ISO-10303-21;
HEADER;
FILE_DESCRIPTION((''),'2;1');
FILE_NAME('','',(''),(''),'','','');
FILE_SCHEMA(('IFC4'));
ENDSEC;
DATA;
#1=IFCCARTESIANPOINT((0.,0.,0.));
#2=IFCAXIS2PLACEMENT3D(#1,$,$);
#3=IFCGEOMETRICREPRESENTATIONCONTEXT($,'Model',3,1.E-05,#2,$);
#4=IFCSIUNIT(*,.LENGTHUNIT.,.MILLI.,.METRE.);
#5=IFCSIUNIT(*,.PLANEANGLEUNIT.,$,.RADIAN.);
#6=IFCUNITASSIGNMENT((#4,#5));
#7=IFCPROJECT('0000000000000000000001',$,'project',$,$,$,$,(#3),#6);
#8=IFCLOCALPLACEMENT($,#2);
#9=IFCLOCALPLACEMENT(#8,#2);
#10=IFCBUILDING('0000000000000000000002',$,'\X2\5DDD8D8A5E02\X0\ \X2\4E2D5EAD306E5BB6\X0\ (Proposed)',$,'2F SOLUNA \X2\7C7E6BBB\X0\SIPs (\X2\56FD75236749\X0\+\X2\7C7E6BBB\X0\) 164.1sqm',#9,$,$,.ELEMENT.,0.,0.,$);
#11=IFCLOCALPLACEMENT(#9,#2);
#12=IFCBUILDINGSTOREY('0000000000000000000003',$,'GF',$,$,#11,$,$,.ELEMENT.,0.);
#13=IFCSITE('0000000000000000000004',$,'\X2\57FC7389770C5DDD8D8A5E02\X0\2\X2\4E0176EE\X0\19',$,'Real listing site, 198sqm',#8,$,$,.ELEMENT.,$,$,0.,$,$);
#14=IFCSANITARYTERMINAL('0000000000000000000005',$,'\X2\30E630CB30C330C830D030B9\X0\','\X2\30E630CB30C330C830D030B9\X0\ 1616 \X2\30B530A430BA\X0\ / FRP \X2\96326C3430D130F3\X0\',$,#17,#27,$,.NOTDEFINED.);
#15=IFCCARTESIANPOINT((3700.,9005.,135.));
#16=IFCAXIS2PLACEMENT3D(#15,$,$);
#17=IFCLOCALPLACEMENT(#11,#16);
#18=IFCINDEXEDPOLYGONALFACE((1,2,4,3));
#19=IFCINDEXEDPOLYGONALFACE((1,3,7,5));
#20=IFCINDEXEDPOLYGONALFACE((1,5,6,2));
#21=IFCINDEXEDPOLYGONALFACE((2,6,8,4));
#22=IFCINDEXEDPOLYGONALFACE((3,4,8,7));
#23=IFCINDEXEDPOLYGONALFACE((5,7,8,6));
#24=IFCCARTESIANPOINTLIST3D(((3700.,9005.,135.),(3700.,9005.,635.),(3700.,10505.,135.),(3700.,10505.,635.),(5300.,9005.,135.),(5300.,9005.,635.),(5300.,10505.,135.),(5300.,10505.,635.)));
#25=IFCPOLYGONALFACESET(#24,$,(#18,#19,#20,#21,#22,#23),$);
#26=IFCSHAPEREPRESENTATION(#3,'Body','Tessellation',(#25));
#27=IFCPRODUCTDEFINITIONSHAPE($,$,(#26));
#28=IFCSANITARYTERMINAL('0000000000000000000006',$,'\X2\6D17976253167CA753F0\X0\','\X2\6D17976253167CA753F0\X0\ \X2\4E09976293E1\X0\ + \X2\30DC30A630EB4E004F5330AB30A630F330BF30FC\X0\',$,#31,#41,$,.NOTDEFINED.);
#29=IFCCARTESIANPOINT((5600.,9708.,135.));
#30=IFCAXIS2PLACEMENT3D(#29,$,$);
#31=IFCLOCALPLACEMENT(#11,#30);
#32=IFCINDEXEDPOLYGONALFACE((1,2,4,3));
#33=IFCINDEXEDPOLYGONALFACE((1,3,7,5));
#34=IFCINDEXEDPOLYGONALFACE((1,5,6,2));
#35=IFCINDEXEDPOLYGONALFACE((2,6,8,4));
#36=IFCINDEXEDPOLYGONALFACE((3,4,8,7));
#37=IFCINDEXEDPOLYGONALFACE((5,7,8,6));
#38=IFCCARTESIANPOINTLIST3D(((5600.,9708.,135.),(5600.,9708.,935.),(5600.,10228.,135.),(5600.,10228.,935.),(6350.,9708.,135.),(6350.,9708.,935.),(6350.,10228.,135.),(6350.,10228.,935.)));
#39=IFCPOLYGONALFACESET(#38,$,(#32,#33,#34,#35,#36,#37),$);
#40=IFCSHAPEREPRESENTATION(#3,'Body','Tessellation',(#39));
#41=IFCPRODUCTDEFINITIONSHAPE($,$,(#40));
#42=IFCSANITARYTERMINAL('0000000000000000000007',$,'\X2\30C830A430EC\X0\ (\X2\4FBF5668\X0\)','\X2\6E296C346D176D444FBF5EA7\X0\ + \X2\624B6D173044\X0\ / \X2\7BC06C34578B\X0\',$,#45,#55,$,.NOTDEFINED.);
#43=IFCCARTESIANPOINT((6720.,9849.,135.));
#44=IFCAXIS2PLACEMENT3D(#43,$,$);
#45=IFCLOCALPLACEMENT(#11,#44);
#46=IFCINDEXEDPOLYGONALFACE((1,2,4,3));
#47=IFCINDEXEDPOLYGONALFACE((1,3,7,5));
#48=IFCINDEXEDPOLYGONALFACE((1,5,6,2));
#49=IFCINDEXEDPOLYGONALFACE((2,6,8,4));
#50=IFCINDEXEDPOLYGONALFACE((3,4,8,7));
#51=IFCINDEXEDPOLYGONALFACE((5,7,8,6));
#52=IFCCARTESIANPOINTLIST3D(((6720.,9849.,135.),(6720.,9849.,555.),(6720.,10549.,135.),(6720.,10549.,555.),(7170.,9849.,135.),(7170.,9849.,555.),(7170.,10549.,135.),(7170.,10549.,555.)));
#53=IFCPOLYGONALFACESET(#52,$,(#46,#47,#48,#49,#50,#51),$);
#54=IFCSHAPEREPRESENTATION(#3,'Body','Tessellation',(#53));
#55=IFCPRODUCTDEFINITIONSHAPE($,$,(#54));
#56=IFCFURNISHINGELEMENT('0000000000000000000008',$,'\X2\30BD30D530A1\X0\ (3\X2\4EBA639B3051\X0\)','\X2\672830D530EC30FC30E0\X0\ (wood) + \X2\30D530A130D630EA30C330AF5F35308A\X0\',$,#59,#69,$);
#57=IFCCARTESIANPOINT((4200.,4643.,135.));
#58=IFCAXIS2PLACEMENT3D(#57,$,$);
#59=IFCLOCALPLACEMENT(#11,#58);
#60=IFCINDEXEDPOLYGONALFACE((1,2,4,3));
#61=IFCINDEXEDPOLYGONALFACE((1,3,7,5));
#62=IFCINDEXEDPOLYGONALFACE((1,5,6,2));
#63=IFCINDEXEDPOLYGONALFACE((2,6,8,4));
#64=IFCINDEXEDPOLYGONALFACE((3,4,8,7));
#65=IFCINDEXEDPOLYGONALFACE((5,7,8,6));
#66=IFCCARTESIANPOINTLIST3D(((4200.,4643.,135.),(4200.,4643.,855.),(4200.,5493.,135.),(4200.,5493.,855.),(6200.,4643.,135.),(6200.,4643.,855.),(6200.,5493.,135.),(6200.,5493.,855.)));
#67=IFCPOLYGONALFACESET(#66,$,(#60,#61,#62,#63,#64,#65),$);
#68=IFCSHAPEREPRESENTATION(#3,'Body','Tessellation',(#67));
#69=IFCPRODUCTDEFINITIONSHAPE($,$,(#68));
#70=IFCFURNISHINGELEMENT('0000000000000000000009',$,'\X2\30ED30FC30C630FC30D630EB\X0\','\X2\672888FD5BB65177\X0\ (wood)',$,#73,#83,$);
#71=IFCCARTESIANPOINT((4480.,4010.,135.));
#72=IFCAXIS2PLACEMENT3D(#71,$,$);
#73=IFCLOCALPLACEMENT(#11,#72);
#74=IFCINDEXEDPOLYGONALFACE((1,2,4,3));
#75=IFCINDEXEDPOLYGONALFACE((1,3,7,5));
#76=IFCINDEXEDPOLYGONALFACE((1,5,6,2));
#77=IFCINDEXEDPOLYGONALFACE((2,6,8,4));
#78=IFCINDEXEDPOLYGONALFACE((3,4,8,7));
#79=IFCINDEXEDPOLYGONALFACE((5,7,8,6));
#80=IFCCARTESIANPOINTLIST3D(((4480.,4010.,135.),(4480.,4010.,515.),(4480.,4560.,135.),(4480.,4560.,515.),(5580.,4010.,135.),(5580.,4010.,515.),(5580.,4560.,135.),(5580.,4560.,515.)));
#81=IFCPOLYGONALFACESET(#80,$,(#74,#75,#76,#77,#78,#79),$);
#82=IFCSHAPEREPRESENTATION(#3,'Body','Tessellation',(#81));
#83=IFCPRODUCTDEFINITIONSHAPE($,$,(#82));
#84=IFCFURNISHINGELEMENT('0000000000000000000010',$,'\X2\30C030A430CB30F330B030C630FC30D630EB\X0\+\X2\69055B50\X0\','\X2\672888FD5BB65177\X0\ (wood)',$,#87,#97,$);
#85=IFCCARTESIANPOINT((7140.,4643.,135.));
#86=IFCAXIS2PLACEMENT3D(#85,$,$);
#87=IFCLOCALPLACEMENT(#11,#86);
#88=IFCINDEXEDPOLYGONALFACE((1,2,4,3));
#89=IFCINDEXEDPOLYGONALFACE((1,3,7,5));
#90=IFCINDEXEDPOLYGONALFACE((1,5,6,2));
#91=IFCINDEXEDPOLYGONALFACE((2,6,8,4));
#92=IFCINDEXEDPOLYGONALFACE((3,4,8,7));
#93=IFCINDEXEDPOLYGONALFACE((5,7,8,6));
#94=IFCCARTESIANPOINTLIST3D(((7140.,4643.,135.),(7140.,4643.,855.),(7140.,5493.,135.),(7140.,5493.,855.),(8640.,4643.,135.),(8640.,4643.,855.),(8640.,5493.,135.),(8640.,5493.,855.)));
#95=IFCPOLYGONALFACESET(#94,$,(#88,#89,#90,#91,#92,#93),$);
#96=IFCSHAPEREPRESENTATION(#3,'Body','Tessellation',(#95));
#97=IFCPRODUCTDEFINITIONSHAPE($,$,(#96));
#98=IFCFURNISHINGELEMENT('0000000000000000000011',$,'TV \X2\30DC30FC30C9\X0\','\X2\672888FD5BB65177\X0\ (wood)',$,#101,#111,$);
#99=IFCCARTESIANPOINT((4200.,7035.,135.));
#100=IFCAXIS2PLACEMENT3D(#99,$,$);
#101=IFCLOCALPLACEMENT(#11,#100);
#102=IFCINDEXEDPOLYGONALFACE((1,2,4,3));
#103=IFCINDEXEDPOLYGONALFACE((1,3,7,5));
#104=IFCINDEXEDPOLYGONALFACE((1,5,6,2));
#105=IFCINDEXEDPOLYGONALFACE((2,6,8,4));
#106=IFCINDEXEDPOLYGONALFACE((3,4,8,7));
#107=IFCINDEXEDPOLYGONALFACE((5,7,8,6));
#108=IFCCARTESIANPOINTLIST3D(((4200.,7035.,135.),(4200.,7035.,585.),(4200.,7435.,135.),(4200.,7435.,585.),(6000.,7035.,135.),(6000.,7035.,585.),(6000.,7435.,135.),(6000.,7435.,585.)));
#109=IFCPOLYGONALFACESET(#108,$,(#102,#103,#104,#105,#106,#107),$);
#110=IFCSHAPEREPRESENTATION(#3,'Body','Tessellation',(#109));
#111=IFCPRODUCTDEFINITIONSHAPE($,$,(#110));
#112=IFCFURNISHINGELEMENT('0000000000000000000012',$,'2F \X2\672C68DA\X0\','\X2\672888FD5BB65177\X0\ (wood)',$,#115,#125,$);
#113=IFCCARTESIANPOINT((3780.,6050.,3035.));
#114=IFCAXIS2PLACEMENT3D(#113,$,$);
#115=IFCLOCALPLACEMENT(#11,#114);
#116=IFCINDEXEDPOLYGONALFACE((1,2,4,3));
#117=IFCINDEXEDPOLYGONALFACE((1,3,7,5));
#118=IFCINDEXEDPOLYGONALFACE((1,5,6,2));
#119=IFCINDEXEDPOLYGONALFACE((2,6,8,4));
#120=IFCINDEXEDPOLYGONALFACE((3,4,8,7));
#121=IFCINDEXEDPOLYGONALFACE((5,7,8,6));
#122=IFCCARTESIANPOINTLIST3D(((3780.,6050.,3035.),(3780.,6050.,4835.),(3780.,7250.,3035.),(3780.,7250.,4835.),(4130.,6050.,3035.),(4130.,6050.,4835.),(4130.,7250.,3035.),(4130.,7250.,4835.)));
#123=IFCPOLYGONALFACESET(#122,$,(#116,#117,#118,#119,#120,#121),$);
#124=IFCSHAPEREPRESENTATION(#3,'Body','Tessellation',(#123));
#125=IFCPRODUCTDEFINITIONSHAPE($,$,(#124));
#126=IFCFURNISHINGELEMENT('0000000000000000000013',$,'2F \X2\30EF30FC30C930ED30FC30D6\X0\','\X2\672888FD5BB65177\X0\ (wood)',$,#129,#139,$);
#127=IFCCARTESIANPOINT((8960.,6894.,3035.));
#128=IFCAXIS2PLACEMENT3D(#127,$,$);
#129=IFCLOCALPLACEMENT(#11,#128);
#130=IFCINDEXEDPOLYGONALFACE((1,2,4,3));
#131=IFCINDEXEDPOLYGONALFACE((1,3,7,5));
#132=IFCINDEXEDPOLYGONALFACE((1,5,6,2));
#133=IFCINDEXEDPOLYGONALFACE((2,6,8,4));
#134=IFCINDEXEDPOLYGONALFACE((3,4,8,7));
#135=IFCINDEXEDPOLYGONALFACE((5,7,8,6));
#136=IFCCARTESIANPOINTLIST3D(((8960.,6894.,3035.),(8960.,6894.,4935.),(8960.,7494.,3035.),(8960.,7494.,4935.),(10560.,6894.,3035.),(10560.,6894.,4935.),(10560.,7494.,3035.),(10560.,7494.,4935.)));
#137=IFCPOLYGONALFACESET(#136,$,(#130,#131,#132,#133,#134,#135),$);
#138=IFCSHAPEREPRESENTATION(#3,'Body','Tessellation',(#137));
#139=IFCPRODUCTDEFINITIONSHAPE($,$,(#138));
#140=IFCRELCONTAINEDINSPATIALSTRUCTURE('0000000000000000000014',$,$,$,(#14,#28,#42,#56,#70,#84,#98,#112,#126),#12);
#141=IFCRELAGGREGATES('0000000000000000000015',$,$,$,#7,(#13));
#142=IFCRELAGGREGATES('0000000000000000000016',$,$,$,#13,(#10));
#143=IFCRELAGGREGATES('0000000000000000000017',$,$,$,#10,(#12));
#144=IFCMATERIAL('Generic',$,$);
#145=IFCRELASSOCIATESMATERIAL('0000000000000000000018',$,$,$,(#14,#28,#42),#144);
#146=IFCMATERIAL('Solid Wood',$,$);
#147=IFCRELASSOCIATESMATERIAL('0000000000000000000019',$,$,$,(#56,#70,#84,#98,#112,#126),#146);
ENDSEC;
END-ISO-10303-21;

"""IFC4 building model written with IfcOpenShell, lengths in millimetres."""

from ifc_helpers import new_model, si_unit, frame, frame_2d, origin, place, context, project, spatial, rectangle, extrude, material, element, save


model = new_model("IFC4")

# Units and contexts
model_context = context("Model", 3, precision=1e-05, world=origin())
ifc_project = project(units=[si_unit("LENGTHUNIT", "METRE", prefix="MILLI"), si_unit("PLANEANGLEUNIT", "RADIAN")], contexts=[model_context])

# Site, building, storey
site_placement = place(None, origin())
site = spatial("IfcSite", under=ifc_project, at=site_placement, Name="埼玉県川越市2丁目19", ObjectType="Real listing site, 198sqm", CompositionType="ELEMENT", RefElevation=0.0)
building_placement = place(site_placement, origin())
building = spatial("IfcBuilding", under=site, at=building_placement, Name="川越市 中庭の家 (Proposed)", ObjectType="2F SOLUNA 籾殻SIPs (国産杉+籾殻) 164.1sqm", CompositionType="ELEMENT", ElevationOfRefHeight=0.0, ElevationOfTerrain=0.0)
storey_placement = place(building_placement, origin())
storey = spatial("IfcBuildingStorey", under=building, at=storey_placement, Name="GF", CompositionType="ELEMENT", Elevation=0.0)

# Shared definitions
ifc_material_1 = material(Name="Generic")

# Shared definitions
ifc_material_2 = material(Name="Solid Wood")

# Sanitary terminals
sanitary_terminal_1_placement = place(storey_placement, frame((3700.0, 9005.0, 135.0)))
element("IfcSanitaryTerminal", 1, at=sanitary_terminal_1_placement, inside=storey, material=ifc_material_1, Name="ユニットバス", Description="ユニットバス 1616 サイズ / FRP 防水パン", PredefinedType="NOTDEFINED", context=model_context, shape_type="SweptSolid", body=[
    extrude(rectangle(XDim=1600.0, YDim=1500.0, at=frame_2d((800.0, 750.0))), frame((3700.0, 9005.0, 135.0)), (0.0, 0.0, 1.0), 500.0),
])
sanitary_terminal_2_placement = place(storey_placement, frame((5600.0, 9708.0, 135.0)))
element("IfcSanitaryTerminal", 2, at=sanitary_terminal_2_placement, inside=storey, material=ifc_material_1, Name="洗面化粧台", Description="洗面化粧台 三面鏡 + ボウル一体カウンター", PredefinedType="NOTDEFINED", context=model_context, shape_type="SweptSolid", body=[
    extrude(rectangle(XDim=750.0, YDim=520.0, at=frame_2d((375.0, 260.0))), frame((5600.0, 9708.0, 135.0)), (0.0, 0.0, 1.0), 800.0),
])
sanitary_terminal_3_placement = place(storey_placement, frame((6720.0, 9849.0, 135.0)))
element("IfcSanitaryTerminal", 3, at=sanitary_terminal_3_placement, inside=storey, material=ifc_material_1, Name="トイレ (便器)", Description="温水洗浄便座 + 手洗い / 節水型", PredefinedType="NOTDEFINED", context=model_context, shape_type="SweptSolid", body=[
    extrude(rectangle(XDim=450.0, YDim=700.0, at=frame_2d((225.0, 350.0))), frame((6720.0, 9849.0, 135.0)), (0.0, 0.0, 1.0), 420.0),
])

# Furnishing elements
furnishing_1_placement = place(storey_placement, frame((4200.0, 4643.0, 135.0)))
element("IfcFurnishingElement", 4, at=furnishing_1_placement, inside=storey, material=ifc_material_2, Name="ソファ (3人掛け)", Description="木フレーム (wood) + ファブリック張り", context=model_context, shape_type="SweptSolid", body=[
    extrude(rectangle(XDim=2000.0, YDim=850.0, at=frame_2d((1000.0, 425.0))), frame((4200.0, 4643.0, 135.0)), (0.0, 0.0, 1.0), 720.0),
])
furnishing_2_placement = place(storey_placement, frame((4480.0, 4010.0, 135.0)))
element("IfcFurnishingElement", 5, at=furnishing_2_placement, inside=storey, material=ifc_material_2, Name="ローテーブル", Description="木製家具 (wood)", context=model_context, shape_type="SweptSolid", body=[
    extrude(rectangle(XDim=1100.0, YDim=550.0, at=frame_2d((550.0, 275.0))), frame((4480.0, 4010.0, 135.0)), (0.0, 0.0, 1.0), 380.0),
])
furnishing_3_placement = place(storey_placement, frame((7140.0, 4643.0, 135.0)))
element("IfcFurnishingElement", 6, at=furnishing_3_placement, inside=storey, material=ifc_material_2, Name="ダイニングテーブル+椅子", Description="木製家具 (wood)", context=model_context, shape_type="SweptSolid", body=[
    extrude(rectangle(XDim=1500.0, YDim=850.0, at=frame_2d((750.0, 425.0))), frame((7140.0, 4643.0, 135.0)), (0.0, 0.0, 1.0), 720.0),
])
furnishing_4_placement = place(storey_placement, frame((4200.0, 7035.0, 135.0)))
element("IfcFurnishingElement", 7, at=furnishing_4_placement, inside=storey, material=ifc_material_2, Name="TV ボード", Description="木製家具 (wood)", context=model_context, shape_type="SweptSolid", body=[
    extrude(rectangle(XDim=1800.0, YDim=400.0, at=frame_2d((900.0, 200.0))), frame((4200.0, 7035.0, 135.0)), (0.0, 0.0, 1.0), 450.0),
])
furnishing_5_placement = place(storey_placement, frame((3780.0, 6050.0, 3035.0)))
element("IfcFurnishingElement", 8, at=furnishing_5_placement, inside=storey, material=ifc_material_2, Name="2F 本棚", Description="木製家具 (wood)", context=model_context, shape_type="SweptSolid", body=[
    extrude(rectangle(XDim=350.0, YDim=1200.0, at=frame_2d((175.0, 600.0))), frame((3780.0, 6050.0, 3035.0)), (0.0, 0.0, 1.0), 1800.0),
])
furnishing_6_placement = place(storey_placement, frame((8960.0, 6894.0, 3035.0)))
element("IfcFurnishingElement", 9, at=furnishing_6_placement, inside=storey, material=ifc_material_2, Name="2F ワードローブ", Description="木製家具 (wood)", context=model_context, shape_type="SweptSolid", body=[
    extrude(rectangle(XDim=1600.0, YDim=600.0, at=frame_2d((800.0, 300.0))), frame((8960.0, 6894.0, 3035.0)), (0.0, 0.0, 1.0), 1900.0),
])

save(model, "model.ifc")
